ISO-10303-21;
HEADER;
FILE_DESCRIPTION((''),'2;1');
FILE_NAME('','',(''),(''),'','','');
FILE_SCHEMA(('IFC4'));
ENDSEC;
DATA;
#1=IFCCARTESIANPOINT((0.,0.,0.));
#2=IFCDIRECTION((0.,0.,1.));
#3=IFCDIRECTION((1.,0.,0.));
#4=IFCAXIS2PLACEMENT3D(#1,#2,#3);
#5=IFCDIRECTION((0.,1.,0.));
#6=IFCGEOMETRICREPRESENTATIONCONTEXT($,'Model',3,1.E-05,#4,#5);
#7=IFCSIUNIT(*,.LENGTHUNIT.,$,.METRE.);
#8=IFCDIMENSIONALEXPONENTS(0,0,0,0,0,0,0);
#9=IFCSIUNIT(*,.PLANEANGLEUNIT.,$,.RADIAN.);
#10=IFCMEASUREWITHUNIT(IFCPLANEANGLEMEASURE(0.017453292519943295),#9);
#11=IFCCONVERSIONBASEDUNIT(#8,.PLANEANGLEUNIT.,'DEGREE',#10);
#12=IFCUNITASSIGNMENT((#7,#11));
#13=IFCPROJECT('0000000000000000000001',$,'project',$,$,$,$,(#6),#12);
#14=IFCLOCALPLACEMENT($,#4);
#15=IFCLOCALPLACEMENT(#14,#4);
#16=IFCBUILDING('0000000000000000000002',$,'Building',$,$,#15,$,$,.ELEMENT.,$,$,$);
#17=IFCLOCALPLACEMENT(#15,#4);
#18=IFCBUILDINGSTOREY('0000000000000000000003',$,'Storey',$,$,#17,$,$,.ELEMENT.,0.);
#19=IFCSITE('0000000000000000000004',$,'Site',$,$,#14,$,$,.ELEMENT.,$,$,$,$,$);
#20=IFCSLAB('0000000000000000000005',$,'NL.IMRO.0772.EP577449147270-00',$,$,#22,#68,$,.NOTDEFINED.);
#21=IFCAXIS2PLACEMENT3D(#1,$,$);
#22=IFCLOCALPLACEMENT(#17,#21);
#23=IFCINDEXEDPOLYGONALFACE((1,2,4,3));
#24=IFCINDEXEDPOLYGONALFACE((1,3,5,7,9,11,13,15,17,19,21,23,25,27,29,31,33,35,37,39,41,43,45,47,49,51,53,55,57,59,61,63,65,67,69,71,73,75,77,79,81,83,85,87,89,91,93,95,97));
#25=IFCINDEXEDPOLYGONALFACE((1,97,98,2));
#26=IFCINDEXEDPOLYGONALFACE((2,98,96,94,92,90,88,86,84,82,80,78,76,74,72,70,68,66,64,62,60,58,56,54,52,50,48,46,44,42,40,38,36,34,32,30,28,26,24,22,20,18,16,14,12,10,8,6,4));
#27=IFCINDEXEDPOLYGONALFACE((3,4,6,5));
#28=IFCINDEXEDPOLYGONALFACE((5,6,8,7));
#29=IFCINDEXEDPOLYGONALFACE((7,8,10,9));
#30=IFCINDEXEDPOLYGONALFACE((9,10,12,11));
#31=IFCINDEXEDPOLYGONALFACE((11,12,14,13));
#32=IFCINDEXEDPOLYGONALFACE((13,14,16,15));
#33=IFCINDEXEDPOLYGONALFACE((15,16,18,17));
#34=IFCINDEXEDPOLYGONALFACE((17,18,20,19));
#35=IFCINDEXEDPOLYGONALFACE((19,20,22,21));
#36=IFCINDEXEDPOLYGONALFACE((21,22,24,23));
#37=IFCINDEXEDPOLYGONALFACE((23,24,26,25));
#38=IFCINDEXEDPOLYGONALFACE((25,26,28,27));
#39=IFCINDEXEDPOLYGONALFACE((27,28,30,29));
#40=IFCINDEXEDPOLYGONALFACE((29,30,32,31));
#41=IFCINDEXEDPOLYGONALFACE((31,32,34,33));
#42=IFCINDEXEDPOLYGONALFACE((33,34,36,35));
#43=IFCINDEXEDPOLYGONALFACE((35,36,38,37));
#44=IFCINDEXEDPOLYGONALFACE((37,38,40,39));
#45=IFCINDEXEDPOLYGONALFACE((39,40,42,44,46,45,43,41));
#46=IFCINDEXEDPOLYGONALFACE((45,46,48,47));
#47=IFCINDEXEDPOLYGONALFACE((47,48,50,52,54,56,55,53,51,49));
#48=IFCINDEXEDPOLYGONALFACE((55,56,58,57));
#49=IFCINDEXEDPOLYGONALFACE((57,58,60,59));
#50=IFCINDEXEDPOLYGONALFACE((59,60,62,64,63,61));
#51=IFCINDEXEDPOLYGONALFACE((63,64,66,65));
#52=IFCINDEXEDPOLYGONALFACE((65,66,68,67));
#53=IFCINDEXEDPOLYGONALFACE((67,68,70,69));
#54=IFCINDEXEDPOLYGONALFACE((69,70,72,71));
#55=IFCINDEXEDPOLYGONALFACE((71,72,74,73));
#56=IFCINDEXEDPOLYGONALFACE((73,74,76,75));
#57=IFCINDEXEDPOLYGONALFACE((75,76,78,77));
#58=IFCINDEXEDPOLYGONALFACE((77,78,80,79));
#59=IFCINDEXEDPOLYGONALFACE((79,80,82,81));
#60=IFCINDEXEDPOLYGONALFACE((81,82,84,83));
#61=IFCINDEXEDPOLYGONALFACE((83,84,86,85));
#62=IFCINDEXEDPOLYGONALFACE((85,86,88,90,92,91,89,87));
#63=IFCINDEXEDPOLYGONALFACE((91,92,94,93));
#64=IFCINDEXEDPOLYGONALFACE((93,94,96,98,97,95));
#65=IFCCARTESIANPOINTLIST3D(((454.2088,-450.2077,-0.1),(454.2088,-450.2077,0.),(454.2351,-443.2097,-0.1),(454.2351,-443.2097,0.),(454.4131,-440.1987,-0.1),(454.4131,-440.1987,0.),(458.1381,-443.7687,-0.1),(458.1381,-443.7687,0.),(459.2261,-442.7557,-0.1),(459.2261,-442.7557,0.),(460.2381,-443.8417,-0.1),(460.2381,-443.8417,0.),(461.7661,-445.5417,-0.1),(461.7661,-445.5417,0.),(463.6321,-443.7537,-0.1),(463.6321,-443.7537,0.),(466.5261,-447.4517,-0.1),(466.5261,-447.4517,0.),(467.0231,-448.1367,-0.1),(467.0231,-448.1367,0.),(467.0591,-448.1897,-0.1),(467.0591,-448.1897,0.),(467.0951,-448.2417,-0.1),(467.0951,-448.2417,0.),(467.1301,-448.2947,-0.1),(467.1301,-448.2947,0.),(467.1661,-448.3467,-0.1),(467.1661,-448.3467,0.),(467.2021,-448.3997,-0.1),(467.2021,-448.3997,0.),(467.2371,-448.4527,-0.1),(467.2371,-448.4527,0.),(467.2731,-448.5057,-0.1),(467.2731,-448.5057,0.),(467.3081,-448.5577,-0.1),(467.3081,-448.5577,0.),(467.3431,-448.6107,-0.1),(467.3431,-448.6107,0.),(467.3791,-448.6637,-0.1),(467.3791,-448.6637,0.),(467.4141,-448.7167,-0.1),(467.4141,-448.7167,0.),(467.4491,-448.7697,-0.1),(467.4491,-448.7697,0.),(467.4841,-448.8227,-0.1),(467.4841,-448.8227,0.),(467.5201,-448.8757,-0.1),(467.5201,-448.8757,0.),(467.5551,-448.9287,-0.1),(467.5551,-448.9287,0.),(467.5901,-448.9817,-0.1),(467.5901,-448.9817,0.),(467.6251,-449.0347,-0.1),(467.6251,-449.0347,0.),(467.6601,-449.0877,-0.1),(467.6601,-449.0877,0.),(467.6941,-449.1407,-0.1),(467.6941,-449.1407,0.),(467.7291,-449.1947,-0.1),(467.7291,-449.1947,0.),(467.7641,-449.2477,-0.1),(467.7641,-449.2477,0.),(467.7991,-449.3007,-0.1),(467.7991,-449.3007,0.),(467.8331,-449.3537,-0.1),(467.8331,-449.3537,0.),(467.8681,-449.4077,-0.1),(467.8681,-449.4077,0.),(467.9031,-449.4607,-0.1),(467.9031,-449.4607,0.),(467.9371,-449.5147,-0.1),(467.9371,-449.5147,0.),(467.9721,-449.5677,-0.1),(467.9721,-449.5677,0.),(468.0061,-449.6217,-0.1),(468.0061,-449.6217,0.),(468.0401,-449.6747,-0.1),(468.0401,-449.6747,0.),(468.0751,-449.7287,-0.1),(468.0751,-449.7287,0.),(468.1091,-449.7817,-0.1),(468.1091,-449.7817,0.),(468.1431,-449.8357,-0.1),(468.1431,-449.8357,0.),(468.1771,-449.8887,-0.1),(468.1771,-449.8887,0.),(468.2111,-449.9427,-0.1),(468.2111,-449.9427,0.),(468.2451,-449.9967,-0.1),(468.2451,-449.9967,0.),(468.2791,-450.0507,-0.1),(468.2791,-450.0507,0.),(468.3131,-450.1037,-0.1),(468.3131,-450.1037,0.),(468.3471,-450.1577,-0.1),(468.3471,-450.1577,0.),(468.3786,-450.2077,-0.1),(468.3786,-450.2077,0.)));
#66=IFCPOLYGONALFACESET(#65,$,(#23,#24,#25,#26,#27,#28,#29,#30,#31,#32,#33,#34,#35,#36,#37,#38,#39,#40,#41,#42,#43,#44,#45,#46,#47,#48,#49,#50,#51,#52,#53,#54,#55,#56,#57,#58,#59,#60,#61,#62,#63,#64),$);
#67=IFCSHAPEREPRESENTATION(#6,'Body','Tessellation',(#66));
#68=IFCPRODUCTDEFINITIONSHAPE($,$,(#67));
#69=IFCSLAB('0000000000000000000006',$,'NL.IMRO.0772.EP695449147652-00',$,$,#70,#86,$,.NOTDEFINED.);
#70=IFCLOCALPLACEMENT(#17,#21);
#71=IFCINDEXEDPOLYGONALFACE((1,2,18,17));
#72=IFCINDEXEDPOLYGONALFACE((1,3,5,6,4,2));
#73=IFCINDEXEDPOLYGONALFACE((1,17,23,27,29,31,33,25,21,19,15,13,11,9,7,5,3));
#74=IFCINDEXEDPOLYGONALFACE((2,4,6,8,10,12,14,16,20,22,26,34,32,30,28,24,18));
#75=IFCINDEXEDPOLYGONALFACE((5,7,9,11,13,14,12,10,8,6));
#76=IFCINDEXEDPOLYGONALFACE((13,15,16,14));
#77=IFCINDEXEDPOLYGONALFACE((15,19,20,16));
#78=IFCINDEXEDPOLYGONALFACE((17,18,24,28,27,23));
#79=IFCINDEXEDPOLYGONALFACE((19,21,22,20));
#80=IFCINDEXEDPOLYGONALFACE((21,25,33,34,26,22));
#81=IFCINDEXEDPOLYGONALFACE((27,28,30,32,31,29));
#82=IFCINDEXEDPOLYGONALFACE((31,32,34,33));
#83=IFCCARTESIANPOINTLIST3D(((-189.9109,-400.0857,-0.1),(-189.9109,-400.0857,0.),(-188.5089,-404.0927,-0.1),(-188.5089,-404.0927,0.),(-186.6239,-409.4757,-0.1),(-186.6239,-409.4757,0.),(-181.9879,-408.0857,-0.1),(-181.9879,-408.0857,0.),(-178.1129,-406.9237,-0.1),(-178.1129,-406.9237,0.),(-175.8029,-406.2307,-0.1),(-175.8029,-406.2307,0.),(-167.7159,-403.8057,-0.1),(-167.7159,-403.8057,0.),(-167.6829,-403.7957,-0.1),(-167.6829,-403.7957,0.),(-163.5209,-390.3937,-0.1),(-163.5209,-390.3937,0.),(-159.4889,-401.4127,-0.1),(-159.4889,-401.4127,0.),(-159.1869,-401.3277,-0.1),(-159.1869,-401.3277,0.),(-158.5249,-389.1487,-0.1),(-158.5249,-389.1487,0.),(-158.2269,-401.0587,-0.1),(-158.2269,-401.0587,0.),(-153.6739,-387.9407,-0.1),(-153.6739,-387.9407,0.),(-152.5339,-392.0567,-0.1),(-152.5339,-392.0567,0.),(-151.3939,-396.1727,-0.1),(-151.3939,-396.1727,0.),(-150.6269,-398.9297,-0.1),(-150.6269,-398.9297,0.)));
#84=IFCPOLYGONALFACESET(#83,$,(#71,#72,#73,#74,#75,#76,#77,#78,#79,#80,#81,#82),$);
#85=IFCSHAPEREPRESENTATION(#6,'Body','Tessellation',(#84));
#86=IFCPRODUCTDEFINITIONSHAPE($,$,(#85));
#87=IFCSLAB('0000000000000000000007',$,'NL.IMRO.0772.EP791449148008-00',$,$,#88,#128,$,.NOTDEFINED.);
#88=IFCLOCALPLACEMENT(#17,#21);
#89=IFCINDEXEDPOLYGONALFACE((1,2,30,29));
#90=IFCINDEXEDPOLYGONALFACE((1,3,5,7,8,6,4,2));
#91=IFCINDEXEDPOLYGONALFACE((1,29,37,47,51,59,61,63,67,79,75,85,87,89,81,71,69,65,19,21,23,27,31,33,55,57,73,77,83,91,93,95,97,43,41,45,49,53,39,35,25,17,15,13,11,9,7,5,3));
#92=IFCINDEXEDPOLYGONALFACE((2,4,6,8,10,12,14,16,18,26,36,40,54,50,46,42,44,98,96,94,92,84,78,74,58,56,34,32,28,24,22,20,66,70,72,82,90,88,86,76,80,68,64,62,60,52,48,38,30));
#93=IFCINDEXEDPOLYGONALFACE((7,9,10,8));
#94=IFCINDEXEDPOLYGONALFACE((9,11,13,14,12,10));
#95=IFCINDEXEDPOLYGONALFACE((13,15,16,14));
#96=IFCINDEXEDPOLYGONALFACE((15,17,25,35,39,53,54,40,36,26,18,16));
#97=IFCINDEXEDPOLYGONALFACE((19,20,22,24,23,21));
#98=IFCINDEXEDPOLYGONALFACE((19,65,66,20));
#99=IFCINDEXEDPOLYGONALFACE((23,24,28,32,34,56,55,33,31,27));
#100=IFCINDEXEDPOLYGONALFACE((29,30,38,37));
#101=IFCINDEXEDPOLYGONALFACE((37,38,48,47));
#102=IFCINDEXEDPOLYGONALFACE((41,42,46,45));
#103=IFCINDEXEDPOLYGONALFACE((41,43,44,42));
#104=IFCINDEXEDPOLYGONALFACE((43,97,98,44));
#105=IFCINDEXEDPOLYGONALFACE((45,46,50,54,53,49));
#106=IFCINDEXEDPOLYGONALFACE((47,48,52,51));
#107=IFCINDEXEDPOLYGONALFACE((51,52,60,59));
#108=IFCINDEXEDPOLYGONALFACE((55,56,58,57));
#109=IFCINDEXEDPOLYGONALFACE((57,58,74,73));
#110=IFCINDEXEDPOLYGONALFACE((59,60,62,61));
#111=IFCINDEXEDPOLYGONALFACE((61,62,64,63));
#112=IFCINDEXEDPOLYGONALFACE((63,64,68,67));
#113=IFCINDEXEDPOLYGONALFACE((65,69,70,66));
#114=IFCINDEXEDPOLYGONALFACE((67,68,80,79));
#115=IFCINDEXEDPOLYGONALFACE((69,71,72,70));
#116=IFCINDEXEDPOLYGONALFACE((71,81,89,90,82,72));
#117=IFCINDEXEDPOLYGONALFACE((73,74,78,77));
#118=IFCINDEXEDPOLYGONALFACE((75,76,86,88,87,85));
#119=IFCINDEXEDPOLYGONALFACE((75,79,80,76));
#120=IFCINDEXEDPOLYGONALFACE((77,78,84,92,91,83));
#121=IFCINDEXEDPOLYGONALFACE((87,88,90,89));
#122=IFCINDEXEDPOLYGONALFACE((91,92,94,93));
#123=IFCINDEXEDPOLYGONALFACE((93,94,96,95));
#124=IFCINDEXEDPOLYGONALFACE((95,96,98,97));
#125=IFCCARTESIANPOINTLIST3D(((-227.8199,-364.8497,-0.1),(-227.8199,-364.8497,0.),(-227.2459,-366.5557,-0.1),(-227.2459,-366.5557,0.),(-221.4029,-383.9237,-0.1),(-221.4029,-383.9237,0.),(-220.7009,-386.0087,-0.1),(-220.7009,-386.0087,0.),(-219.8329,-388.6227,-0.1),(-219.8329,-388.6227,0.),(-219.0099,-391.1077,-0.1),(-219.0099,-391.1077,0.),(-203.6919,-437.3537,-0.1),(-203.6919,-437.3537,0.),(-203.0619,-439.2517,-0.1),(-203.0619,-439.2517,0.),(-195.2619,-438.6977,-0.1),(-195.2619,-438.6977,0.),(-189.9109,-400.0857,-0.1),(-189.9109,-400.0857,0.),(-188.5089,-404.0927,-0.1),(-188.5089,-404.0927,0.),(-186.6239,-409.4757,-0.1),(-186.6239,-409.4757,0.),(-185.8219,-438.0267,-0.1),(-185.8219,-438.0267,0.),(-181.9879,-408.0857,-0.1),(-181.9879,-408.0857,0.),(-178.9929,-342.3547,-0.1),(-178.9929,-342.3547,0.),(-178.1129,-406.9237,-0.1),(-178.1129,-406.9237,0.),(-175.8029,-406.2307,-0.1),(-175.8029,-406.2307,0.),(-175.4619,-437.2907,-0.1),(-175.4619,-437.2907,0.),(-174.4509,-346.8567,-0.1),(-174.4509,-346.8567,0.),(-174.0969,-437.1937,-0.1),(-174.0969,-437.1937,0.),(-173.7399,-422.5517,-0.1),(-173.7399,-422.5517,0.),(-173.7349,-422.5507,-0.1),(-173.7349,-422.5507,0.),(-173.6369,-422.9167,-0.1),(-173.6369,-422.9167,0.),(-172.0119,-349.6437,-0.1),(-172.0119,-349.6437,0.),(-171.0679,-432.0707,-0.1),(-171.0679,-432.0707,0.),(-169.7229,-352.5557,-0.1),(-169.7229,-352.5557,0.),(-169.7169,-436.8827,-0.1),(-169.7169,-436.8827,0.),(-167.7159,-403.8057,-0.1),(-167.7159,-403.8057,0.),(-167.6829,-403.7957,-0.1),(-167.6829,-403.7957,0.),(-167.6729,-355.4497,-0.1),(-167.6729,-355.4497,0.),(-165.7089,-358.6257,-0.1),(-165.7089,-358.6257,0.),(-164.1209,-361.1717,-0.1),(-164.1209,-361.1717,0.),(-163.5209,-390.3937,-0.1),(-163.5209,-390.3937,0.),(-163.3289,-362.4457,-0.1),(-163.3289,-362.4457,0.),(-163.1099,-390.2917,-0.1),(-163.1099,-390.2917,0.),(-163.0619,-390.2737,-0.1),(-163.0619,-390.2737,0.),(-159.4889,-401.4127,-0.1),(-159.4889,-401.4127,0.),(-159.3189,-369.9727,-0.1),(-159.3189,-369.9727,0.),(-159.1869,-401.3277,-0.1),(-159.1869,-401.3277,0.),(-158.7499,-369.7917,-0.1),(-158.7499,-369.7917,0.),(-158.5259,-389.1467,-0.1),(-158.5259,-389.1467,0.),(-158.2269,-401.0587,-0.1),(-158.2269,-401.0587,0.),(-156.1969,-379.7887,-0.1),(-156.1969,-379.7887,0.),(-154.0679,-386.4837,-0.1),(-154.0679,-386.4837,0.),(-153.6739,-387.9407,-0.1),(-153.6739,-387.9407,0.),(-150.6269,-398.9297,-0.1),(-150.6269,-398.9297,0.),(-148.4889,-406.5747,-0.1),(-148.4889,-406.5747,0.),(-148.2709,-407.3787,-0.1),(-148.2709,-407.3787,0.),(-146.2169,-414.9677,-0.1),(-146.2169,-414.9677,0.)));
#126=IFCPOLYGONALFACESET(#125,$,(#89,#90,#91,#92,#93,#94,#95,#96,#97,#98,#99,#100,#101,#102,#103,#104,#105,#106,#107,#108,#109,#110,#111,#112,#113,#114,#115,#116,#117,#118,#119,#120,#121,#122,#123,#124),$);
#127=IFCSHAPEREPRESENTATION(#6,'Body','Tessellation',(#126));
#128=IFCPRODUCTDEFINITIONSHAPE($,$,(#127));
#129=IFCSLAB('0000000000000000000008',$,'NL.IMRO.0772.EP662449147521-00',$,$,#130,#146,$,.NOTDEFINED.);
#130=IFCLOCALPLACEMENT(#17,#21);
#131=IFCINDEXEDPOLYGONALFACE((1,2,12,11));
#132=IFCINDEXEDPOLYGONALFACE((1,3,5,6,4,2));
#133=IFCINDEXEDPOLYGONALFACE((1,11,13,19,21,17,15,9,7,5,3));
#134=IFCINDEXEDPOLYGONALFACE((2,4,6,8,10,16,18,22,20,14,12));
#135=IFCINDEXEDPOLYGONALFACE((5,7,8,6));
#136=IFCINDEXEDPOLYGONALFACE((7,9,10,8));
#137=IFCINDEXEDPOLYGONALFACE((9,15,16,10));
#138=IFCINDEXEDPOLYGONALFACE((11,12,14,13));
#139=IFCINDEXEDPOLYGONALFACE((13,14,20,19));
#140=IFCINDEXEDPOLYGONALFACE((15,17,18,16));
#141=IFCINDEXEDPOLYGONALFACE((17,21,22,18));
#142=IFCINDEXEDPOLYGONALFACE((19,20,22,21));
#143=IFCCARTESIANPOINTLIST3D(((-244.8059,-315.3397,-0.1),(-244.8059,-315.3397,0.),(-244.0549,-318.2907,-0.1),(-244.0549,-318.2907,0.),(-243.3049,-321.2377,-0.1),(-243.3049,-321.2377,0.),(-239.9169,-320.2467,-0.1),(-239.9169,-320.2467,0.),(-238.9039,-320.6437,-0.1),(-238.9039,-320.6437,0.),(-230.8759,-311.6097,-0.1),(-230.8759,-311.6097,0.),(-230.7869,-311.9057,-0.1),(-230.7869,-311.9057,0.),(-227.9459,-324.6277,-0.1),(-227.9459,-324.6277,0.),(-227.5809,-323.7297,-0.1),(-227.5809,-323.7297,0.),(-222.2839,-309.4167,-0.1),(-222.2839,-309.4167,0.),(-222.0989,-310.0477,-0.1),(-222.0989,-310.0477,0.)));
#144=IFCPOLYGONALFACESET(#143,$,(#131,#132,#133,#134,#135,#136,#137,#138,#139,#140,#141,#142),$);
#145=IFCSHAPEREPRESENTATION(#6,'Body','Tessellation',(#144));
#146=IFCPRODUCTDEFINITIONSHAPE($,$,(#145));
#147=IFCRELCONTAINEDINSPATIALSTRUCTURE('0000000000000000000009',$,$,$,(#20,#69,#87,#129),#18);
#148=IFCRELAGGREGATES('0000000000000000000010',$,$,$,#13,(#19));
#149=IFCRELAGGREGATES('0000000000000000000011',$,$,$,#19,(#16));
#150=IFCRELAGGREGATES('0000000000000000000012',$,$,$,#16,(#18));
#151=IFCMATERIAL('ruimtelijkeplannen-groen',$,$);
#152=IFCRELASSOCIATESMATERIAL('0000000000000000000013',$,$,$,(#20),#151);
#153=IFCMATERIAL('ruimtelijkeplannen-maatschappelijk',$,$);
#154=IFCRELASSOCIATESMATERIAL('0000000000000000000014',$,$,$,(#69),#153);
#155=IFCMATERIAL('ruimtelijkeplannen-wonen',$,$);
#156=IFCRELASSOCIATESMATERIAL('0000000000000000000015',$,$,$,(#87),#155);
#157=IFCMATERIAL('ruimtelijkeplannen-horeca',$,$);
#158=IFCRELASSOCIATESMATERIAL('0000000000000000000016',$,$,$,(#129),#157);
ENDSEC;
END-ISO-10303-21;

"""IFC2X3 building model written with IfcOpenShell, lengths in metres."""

from ifc_helpers import new_model, entity, si_unit, converted_unit, direction, frame, origin_with_axes, place, context, project, spatial, polyline, outline, extrude, material, element, save


model = new_model("IFC2X3")

# Units and contexts
model_context = context("Model", 3, precision=1e-05, world=origin_with_axes(), true_north=direction((0.0, 1.0, 0.0)))
ifc_project = project(units=[si_unit("LENGTHUNIT", "METRE"), converted_unit("PLANEANGLEUNIT", "DEGREE", entity("IfcPlaneAngleMeasure", 0.017453292519943295), si_unit("PLANEANGLEUNIT", "RADIAN"), dimensions=[0, 0, 0, 0, 0, 0, 0])], contexts=[model_context])

# Site, building, storey
site_placement = place(None, origin_with_axes())
site = spatial("IfcSite", under=ifc_project, at=site_placement, Name="Site", CompositionType="ELEMENT")
building_placement = place(site_placement, origin_with_axes())
building = spatial("IfcBuilding", under=site, at=building_placement, Name="Building", CompositionType="ELEMENT")
storey_placement = place(building_placement, origin_with_axes())
storey = spatial("IfcBuildingStorey", under=building, at=storey_placement, Name="Storey", CompositionType="ELEMENT", Elevation=0.0)

# Slabs
ifc_material_1 = material(Name="ruimtelijkeplannen-wonen")
ifc_material_2 = material(Name="ruimtelijkeplannen-horeca")
ifc_material_3 = material(Name="ruimtelijkeplannen-maatschappelijk")
ifc_material_4 = material(Name="ruimtelijkeplannen-groen")
slab_1_placement = place(storey_placement, frame((0.0, 0.0, -0.1), z_axis=(0.0, 0.0, 1.0), x_axis=(1.0, 0.0, 0.0)))
element("IfcSlab", 1, at=slab_1_placement, inside=storey, material=ifc_material_4, Name="NL.IMRO.0772.EP577449147270-00", PredefinedType="NOTDEFINED", context=model_context, shape_type="SweptSolid", body=[
    extrude(outline(polyline([(454.2351, -443.2097), (454.4131, -440.1987), (458.1381, -443.7687), (459.2261, -442.7557), (460.2381, -443.8417), (461.7661, -445.5417), (463.6321, -443.7537), (466.5261, -447.4517), (467.0231, -448.1367), (467.0591, -448.1897), (467.0951, -448.2417), (467.1301, -448.2947), (467.1661, -448.3467), (467.2021, -448.3997), (467.2371, -448.4527), (467.2731, -448.5057), (467.3081, -448.5577), (467.3431, -448.6107), (467.3791, -448.6637), (467.4141, -448.7167), (467.4491, -448.7697), (467.4841, -448.8227), (467.5201, -448.8757), (467.5551, -448.9287), (467.5901, -448.9817), (467.6251, -449.0347), (467.6601, -449.0877), (467.6941, -449.1407), (467.7291, -449.1947), (467.7641, -449.2477), (467.7991, -449.3007), (467.8331, -449.3537), (467.8681, -449.4077), (467.9031, -449.4607), (467.9371, -449.5147), (467.9721, -449.5677), (468.0061, -449.6217), (468.0401, -449.6747), (468.0751, -449.7287), (468.1091, -449.7817), (468.1431, -449.8357), (468.1771, -449.8887), (468.2111, -449.9427), (468.2451, -449.9967), (468.2791, -450.0507), (468.3131, -450.1037), (468.3471, -450.1577), (468.3786, -450.2077), (454.2088, -450.2077), (454.2351, -443.2097)])), origin_with_axes(), (0.0, 0.0, 1.0), 0.1),
])
slab_2_placement = place(storey_placement, frame((0.0, 0.0, -0.1), z_axis=(0.0, 0.0, 1.0), x_axis=(1.0, 0.0, 0.0)))
element("IfcSlab", 2, at=slab_2_placement, inside=storey, material=ifc_material_3, Name="NL.IMRO.0772.EP695449147652-00", PredefinedType="NOTDEFINED", context=model_context, shape_type="SweptSolid", body=[
    extrude(outline(polyline([(-152.5339, -392.0567), (-151.3939, -396.1727), (-150.6269, -398.9297), (-158.2269, -401.0587), (-159.1869, -401.3277), (-159.4889, -401.4127), (-167.6829, -403.7957), (-167.7159, -403.8057), (-175.8029, -406.2307), (-178.1129, -406.9237), (-181.9879, -408.0857), (-186.6239, -409.4757), (-188.5089, -404.0927), (-189.9109, -400.0857), (-163.5209, -390.3937), (-158.5249, -389.1487), (-153.6739, -387.9407), (-152.5339, -392.0567)])), origin_with_axes(), (0.0, 0.0, 1.0), 0.1),
])
slab_3_placement = place(storey_placement, frame((0.0, 0.0, -0.1), z_axis=(0.0, 0.0, 1.0), x_axis=(1.0, 0.0, 0.0)))
element("IfcSlab", 3, at=slab_3_placement, inside=storey, material=ifc_material_1, Name="NL.IMRO.0772.EP791449148008-00", PredefinedType="NOTDEFINED", context=model_context, shape_type="SweptSolid", body=[
    extrude(outline(polyline([(-156.1969, -379.7887), (-154.0679, -386.4837), (-153.6739, -387.9407), (-158.5259, -389.1467), (-163.0619, -390.2737), (-163.1099, -390.2917), (-163.5209, -390.3937), (-189.9109, -400.0857), (-188.5089, -404.0927), (-186.6239, -409.4757), (-181.9879, -408.0857), (-178.1129, -406.9237), (-175.8029, -406.2307), (-167.7159, -403.8057), (-167.6829, -403.7957), (-159.4889, -401.4127), (-159.1869, -401.3277), (-158.2269, -401.0587), (-150.6269, -398.9297), (-148.4889, -406.5747), (-148.2709, -407.3787), (-146.2169, -414.9677), (-173.7349, -422.5507), (-173.7399, -422.5517), (-173.6369, -422.9167), (-171.0679, -432.0707), (-169.7169, -436.8827), (-174.0969, -437.1937), (-175.4619, -437.2907), (-185.8219, -438.0267), (-195.2619, -438.6977), (-203.0619, -439.2517), (-203.6919, -437.3537), (-219.0099, -391.1077), (-219.8329, -388.6227), (-220.7009, -386.0087), (-221.4029, -383.9237), (-227.2459, -366.5557), (-227.8199, -364.8497), (-178.9929, -342.3547), (-174.4509, -346.8567), (-172.0119, -349.6437), (-169.7229, -352.5557), (-167.6729, -355.4497), (-165.7089, -358.6257), (-164.1209, -361.1717), (-163.3289, -362.4457), (-158.7499, -369.7917), (-159.3189, -369.9727), (-156.1969, -379.7887)])), origin_with_axes(), (0.0, 0.0, 1.0), 0.1),
])
slab_4_placement = place(storey_placement, frame((0.0, 0.0, -0.1), z_axis=(0.0, 0.0, 1.0), x_axis=(1.0, 0.0, 0.0)))
element("IfcSlab", 4, at=slab_4_placement, inside=storey, material=ifc_material_2, Name="NL.IMRO.0772.EP662449147521-00", PredefinedType="NOTDEFINED", context=model_context, shape_type="SweptSolid", body=[
    extrude(outline(polyline([(-243.3049, -321.2377), (-244.0549, -318.2907), (-244.8059, -315.3397), (-230.8759, -311.6097), (-230.7869, -311.9057), (-222.2839, -309.4167), (-222.0989, -310.0477), (-227.5809, -323.7297), (-227.9459, -324.6277), (-238.9039, -320.6437), (-239.9169, -320.2467), (-243.3049, -321.2377)])), origin_with_axes(), (0.0, 0.0, 1.0), 0.1),
])

save(model, "model.ifc")
